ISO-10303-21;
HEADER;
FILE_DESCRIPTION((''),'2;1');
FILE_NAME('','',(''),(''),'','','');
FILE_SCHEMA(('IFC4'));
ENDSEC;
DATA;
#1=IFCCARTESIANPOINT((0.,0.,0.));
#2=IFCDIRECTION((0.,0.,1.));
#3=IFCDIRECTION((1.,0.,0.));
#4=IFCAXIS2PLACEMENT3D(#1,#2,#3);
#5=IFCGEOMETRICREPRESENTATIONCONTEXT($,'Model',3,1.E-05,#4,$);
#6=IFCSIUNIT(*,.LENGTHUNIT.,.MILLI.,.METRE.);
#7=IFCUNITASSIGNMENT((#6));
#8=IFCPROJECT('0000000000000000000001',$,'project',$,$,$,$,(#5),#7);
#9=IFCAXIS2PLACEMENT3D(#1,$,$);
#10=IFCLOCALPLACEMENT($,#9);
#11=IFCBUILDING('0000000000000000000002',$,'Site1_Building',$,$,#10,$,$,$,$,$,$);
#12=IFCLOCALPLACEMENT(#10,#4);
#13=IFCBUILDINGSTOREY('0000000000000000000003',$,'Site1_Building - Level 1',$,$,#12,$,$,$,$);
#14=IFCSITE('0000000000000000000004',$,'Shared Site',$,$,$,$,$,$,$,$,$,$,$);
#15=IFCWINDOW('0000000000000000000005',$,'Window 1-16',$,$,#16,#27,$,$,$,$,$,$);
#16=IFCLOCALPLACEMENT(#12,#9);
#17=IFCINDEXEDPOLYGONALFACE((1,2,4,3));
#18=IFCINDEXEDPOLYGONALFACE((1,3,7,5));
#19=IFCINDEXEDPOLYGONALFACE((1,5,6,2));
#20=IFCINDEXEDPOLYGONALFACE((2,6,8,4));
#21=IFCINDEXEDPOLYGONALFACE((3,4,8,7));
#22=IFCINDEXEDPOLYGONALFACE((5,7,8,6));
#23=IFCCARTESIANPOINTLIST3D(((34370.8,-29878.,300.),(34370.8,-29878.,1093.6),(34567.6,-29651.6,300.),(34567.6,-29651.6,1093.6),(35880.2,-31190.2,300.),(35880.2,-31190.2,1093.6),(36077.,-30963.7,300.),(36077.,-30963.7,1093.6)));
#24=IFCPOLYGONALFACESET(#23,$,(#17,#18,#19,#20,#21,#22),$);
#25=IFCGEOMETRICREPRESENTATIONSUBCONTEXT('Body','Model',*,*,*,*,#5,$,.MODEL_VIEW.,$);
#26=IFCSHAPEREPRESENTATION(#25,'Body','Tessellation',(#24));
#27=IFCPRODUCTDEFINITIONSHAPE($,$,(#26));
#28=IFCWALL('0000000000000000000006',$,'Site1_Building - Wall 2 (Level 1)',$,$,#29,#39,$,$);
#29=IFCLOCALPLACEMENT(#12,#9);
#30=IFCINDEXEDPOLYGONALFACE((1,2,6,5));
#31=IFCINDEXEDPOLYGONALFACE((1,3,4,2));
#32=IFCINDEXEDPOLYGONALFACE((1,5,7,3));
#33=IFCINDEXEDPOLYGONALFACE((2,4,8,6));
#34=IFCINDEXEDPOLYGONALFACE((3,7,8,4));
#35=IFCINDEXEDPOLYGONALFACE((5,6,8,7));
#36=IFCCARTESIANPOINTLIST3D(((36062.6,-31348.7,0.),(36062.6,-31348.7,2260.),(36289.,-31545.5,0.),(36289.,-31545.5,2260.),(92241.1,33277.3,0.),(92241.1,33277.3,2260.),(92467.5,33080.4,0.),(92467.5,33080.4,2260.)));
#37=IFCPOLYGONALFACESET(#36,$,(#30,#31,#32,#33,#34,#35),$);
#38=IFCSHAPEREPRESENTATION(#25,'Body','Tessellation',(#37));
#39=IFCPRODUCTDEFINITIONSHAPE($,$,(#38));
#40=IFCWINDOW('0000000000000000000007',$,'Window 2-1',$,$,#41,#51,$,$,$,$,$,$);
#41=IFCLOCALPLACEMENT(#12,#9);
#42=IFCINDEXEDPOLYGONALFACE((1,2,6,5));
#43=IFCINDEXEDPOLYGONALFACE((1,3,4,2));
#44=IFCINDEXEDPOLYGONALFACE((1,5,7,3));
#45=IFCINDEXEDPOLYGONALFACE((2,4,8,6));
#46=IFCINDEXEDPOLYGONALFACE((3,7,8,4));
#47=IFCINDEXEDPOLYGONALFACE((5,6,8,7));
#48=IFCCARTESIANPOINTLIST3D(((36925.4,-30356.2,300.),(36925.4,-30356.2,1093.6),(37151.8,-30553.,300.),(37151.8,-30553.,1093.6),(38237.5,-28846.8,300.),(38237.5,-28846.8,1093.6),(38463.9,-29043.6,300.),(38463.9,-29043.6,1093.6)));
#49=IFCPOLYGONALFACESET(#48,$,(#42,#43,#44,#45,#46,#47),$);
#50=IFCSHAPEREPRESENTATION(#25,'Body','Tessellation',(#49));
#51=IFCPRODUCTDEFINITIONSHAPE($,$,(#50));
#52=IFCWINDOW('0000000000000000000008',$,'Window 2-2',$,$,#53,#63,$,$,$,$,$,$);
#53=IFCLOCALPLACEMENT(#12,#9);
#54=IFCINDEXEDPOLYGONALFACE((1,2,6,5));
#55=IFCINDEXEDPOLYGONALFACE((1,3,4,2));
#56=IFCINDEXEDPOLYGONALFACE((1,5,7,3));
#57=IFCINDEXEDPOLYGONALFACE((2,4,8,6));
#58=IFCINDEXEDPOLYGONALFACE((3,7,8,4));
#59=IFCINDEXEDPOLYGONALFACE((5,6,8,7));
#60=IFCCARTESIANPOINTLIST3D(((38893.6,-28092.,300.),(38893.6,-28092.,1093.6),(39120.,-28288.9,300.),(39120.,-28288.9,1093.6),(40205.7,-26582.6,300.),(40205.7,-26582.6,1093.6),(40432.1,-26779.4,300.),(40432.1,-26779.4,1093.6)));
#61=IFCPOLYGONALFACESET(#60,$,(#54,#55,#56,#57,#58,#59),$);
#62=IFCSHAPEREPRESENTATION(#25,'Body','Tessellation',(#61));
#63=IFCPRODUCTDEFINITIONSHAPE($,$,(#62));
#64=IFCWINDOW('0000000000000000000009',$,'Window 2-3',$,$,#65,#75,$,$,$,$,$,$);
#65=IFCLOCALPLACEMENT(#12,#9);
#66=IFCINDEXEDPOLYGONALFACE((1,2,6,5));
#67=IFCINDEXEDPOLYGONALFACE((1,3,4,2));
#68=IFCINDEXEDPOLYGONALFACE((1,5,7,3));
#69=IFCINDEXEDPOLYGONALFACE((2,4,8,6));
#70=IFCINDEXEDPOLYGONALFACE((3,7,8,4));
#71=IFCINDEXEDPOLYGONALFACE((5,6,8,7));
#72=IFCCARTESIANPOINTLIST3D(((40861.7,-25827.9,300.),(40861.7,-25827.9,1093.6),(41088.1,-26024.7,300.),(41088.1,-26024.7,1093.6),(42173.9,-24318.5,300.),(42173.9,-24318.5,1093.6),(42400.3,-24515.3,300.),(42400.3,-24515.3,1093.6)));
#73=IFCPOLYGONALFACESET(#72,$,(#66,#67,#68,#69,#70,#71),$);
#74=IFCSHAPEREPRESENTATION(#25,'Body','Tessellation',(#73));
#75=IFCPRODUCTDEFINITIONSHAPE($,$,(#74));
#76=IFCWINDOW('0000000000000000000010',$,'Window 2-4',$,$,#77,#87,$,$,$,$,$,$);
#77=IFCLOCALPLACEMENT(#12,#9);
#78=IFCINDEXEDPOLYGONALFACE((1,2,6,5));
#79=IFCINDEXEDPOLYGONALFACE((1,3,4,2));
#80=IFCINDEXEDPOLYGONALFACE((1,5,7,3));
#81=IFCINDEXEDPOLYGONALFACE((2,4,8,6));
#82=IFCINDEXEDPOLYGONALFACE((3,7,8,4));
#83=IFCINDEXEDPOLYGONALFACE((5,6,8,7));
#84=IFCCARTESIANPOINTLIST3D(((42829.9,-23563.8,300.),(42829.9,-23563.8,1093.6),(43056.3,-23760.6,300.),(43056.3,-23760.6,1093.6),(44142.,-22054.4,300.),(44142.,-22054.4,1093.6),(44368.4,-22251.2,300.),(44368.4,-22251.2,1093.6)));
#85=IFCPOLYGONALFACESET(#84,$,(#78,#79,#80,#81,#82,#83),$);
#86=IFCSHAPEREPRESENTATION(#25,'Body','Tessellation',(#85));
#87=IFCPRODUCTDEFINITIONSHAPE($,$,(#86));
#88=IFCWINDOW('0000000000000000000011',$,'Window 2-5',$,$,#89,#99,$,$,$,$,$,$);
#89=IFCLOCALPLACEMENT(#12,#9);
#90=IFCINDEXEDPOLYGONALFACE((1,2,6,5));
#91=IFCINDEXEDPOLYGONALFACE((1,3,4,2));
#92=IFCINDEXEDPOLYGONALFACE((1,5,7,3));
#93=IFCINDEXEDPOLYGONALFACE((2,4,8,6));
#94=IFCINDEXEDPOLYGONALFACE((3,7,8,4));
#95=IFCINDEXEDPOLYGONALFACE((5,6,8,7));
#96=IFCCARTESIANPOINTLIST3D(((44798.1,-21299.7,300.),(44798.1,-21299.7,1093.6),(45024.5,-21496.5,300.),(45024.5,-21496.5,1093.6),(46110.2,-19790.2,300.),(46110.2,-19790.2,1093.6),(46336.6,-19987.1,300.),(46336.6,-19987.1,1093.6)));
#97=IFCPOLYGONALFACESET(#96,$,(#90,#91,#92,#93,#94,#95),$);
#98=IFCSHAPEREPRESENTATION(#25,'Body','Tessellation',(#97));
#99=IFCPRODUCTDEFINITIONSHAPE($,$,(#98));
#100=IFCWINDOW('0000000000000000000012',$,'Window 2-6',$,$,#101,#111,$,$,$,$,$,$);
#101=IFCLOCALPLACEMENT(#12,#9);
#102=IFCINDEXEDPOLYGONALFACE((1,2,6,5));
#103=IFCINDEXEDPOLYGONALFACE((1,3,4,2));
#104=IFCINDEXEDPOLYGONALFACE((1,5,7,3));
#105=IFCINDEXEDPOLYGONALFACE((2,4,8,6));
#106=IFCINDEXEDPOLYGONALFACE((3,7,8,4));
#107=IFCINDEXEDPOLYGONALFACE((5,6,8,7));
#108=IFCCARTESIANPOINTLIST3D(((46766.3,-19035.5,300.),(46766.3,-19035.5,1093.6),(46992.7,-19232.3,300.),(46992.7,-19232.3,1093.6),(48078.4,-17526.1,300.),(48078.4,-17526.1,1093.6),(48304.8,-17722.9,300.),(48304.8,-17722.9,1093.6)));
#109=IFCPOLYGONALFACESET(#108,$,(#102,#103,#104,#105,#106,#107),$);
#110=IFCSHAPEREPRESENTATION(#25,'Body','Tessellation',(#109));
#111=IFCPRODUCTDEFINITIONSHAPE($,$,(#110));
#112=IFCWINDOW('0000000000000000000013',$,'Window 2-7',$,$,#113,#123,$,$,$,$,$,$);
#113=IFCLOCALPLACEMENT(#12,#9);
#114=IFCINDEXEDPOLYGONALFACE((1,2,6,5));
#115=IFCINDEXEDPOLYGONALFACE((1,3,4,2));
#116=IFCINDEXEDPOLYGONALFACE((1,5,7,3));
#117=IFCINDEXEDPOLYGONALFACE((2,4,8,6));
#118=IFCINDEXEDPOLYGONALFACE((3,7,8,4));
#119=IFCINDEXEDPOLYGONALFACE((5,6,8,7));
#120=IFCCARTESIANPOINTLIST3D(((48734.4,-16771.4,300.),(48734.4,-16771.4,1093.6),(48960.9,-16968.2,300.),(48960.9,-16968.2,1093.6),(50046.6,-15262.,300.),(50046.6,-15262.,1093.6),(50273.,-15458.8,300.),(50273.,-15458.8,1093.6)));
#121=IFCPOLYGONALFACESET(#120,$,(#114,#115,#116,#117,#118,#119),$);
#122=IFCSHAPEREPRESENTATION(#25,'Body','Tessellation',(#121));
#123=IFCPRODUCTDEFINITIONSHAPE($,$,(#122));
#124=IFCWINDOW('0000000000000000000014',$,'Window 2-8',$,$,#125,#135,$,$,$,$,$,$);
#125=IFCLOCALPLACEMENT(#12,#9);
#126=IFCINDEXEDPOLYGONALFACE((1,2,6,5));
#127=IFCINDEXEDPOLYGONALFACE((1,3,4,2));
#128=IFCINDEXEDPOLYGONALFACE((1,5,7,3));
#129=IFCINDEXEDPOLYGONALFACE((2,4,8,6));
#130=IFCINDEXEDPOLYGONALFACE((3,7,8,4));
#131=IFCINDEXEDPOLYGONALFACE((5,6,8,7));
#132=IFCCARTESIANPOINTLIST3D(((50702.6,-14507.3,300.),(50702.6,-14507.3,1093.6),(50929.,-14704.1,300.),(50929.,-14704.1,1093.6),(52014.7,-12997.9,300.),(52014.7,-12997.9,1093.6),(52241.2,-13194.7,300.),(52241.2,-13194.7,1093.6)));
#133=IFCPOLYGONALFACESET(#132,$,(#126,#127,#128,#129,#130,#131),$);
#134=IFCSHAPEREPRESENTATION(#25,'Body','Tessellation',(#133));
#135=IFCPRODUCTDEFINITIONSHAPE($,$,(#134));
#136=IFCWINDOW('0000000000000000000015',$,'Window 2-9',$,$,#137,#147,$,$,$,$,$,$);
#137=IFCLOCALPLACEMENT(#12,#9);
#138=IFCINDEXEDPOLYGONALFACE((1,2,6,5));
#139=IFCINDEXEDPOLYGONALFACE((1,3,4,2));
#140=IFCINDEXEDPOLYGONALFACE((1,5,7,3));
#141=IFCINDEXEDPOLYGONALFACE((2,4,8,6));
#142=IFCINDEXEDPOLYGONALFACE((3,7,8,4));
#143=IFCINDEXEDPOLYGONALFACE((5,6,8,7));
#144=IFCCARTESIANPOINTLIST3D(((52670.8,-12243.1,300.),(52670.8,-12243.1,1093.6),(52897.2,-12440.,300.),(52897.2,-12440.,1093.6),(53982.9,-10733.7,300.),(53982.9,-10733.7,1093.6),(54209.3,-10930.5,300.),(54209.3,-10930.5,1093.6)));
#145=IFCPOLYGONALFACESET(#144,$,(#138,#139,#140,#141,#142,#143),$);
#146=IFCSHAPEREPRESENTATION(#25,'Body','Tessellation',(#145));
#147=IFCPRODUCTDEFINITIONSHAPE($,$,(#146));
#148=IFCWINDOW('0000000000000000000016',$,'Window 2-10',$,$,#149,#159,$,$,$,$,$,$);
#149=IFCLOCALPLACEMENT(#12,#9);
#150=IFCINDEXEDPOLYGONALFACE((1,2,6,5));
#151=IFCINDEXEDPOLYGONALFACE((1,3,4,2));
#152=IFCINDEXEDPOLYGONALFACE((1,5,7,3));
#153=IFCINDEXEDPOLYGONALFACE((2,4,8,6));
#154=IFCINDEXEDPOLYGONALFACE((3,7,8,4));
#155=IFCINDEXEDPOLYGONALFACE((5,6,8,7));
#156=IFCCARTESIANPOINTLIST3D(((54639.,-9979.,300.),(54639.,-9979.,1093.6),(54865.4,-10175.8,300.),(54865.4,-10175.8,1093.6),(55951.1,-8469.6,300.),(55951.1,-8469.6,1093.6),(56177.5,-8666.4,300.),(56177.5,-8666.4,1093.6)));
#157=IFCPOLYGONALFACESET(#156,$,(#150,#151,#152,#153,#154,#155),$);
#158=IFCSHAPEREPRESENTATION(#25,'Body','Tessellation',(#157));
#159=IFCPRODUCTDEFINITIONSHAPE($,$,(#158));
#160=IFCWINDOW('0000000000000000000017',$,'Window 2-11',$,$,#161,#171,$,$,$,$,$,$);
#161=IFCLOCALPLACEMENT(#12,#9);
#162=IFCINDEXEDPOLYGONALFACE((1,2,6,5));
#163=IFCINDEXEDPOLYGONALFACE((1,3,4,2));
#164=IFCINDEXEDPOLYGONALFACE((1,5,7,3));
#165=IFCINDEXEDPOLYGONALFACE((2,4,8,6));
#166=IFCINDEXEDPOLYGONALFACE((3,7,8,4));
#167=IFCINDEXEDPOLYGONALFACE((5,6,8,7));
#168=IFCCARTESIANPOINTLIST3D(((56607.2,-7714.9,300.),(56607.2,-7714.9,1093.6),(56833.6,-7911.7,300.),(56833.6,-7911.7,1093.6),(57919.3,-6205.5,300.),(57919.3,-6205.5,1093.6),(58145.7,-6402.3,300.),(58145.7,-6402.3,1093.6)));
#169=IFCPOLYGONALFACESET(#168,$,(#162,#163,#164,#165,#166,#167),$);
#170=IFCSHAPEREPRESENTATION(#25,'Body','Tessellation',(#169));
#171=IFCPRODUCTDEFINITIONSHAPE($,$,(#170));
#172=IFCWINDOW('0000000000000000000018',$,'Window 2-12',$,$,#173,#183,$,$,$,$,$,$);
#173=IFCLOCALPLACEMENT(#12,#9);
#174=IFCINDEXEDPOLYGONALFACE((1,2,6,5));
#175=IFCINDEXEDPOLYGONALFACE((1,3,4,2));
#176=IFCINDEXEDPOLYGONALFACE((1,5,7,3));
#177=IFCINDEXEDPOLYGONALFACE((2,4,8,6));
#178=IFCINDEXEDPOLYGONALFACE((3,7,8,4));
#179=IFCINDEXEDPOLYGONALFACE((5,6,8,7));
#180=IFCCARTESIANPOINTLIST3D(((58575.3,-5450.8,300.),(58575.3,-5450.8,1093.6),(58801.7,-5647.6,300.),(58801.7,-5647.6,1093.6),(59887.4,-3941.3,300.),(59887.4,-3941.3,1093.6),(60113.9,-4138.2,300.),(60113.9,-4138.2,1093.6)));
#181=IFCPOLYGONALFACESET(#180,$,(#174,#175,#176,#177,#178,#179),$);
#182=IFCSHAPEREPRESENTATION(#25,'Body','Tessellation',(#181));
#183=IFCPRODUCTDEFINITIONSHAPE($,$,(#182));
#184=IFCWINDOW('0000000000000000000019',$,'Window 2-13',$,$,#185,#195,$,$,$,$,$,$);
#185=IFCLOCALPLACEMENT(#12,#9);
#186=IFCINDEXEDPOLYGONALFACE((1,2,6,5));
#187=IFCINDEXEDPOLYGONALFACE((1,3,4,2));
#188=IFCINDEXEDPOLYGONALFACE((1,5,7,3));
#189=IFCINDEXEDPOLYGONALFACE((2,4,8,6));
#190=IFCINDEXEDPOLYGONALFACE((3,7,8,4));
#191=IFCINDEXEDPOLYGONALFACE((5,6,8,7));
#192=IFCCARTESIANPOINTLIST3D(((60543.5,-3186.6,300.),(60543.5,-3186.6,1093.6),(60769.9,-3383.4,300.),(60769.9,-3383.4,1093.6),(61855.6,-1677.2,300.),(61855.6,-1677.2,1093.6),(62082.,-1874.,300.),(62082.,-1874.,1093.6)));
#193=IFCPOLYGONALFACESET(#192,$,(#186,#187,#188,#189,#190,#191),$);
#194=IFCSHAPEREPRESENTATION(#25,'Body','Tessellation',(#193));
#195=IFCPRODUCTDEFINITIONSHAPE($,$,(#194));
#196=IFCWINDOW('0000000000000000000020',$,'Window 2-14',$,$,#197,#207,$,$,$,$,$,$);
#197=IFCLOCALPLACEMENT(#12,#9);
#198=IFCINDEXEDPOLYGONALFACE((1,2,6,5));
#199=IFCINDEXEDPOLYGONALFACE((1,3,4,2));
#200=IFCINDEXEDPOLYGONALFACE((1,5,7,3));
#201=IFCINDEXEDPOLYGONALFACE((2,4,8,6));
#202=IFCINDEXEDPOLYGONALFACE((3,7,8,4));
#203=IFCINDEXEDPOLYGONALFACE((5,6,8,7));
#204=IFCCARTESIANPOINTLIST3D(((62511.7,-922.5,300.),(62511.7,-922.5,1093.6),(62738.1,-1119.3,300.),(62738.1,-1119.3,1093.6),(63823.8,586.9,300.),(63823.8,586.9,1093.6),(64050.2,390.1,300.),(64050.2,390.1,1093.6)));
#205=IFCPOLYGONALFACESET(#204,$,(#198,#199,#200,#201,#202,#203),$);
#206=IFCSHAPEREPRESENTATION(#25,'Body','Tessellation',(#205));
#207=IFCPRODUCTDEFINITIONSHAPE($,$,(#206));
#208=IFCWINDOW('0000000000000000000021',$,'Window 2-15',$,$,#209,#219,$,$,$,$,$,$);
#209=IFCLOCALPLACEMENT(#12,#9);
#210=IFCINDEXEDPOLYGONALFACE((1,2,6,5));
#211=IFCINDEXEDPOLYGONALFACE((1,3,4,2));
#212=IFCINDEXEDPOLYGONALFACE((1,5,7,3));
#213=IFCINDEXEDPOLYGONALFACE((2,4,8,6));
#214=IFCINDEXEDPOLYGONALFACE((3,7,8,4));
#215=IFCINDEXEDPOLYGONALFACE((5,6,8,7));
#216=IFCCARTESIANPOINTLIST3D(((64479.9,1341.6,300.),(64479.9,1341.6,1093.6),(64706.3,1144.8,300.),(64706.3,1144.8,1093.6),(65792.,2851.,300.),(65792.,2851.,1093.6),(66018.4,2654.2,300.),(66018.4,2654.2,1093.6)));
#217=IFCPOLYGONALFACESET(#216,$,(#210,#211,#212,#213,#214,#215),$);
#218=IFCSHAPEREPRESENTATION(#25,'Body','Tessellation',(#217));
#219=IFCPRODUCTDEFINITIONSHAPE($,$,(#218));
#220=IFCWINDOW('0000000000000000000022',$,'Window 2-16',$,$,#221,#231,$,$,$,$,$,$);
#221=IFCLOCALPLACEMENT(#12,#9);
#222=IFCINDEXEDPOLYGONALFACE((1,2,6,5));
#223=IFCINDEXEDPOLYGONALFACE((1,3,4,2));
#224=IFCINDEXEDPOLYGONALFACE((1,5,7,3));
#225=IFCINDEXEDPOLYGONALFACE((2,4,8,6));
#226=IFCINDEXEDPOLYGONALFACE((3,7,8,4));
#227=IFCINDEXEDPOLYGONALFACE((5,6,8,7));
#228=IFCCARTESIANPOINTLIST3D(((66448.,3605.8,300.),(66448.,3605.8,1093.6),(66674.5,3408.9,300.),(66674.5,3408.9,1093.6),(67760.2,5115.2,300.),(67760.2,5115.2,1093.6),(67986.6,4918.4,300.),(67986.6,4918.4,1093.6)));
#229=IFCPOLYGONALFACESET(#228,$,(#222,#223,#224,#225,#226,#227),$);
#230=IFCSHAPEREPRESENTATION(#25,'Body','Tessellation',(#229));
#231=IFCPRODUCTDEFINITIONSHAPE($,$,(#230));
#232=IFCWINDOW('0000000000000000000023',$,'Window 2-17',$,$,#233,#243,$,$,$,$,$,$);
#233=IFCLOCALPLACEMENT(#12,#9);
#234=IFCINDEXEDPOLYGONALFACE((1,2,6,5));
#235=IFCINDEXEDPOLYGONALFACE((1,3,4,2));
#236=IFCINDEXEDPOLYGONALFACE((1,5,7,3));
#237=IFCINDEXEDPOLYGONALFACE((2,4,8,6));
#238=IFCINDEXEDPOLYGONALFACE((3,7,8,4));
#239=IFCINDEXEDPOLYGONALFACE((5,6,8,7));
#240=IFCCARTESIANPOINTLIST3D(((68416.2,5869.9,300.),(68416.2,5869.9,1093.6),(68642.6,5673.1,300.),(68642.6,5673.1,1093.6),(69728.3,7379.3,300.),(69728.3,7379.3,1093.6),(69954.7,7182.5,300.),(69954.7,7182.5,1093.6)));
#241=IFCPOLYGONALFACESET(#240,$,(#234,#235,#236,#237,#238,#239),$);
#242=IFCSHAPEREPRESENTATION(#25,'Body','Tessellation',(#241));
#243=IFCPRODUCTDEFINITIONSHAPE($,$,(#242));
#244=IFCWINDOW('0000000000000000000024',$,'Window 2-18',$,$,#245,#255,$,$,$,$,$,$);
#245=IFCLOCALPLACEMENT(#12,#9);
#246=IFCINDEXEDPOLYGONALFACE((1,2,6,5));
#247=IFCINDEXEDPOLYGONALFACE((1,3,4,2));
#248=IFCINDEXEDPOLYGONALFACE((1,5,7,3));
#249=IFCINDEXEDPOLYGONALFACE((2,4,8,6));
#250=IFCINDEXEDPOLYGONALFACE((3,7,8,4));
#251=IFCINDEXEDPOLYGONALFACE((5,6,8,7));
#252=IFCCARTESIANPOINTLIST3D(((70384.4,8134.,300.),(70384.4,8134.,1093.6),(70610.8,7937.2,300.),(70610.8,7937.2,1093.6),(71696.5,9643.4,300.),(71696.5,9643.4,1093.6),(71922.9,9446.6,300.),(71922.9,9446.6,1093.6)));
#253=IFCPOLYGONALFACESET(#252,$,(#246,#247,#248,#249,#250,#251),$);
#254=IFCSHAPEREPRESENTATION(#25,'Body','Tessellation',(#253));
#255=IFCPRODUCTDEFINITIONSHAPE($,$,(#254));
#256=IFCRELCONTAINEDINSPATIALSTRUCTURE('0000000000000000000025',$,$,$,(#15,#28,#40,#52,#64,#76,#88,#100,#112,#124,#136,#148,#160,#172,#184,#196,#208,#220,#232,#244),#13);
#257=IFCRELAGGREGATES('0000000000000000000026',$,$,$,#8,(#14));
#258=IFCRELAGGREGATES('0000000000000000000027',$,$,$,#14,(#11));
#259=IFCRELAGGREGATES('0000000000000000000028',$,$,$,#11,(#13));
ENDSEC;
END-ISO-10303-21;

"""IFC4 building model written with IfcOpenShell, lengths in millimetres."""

from ifc_helpers import new_model, si_unit, frame, origin, origin_with_axes, place, context, subcontext, project, spatial, indexed_curve, outline, extrude, element, save


model = new_model("IFC4")

# Units and contexts
model_context = context("Model", 3, precision=1e-05, world=origin_with_axes())
body_context = subcontext(model_context, "Body", "Model", "MODEL_VIEW")
ifc_project = project(units=[si_unit("LENGTHUNIT", "METRE", prefix="MILLI")], contexts=[model_context])

# Site, building, storey
site = spatial("IfcSite", under=ifc_project, Name="Shared Site")
building_placement = place(None, origin())
building = spatial("IfcBuilding", under=site, at=building_placement, Name="Site1_Building")
storey_placement = place(building_placement, origin_with_axes())
storey = spatial("IfcBuildingStorey", under=building, at=storey_placement, Name="Site1_Building - Level 1")

# Window
window_placement = place(storey_placement, frame((34370.8, -29878.0, 300.0), z_axis=(0.0, 0.0, 1.0), x_axis=(0.75471, -0.656059, 0.0)))
element("IfcWindow", 1, at=window_placement, inside=storey, Name="Window 1-16", context=body_context, shape_type="SweptSolid", body=[
    extrude(outline(indexed_curve([(0.0, 0.0), (0.0, 300.0), (2000.0, 300.0), (2000.0, 0.0), (0.0, 0.0)], self_intersect=False)), origin_with_axes(), (0.0, 0.0, 1.0), 793.6),
])

# Wall
wall_placement = place(storey_placement, frame((36289.0, -31545.5, 0.0), z_axis=(0.0, 0.0, 1.0), x_axis=(0.656059, 0.75471, 0.0)))
element("IfcWall", 2, at=wall_placement, inside=storey, Name="Site1_Building - Wall 2 (Level 1)", context=body_context, shape_type="SweptSolid", body=[
    extrude(outline(indexed_curve([(0.0, 0.0), (0.0, 300.0), (85630.3, 300.0), (85630.3, 0.0), (0.0, 0.0)], self_intersect=False)), origin_with_axes(), (0.0, 0.0, 1.0), 2260.0),
])

# Windows
for number, where, z_axis, x_axis, name in (
    (3, (37151.8, -30553.0, 300.0), (0.0, 0.0, 1.0), (0.656059, 0.75471, 0.0), "Window 2-1"),
    (4, (39120.0, -28288.9, 300.0), (0.0, 0.0, 1.0), (0.656059, 0.75471, 0.0), "Window 2-2"),
    (5, (41088.1, -26024.7, 300.0), (0.0, 0.0, 1.0), (0.656059, 0.75471, 0.0), "Window 2-3"),
    (6, (43056.3, -23760.6, 300.0), (0.0, 0.0, 1.0), (0.656059, 0.75471, 0.0), "Window 2-4"),
    (7, (45024.5, -21496.5, 300.0), (0.0, 0.0, 1.0), (0.656059, 0.75471, 0.0), "Window 2-5"),
    (8, (46992.7, -19232.3, 300.0), (0.0, 0.0, 1.0), (0.656059, 0.75471, 0.0), "Window 2-6"),
    (9, (48960.9, -16968.2, 300.0), (0.0, 0.0, 1.0), (0.656059, 0.75471, 0.0), "Window 2-7"),
    (10, (50929.0, -14704.1, 300.0), (0.0, 0.0, 1.0), (0.656059, 0.75471, 0.0), "Window 2-8"),
    (11, (52897.2, -12440.0, 300.0), (0.0, 0.0, 1.0), (0.656059, 0.75471, 0.0), "Window 2-9"),
    (12, (54865.4, -10175.8, 300.0), (0.0, 0.0, 1.0), (0.656059, 0.75471, 0.0), "Window 2-10"),
    (13, (56833.6, -7911.7, 300.0), (0.0, 0.0, 1.0), (0.656059, 0.75471, 0.0), "Window 2-11"),
    (14, (58801.7, -5647.6, 300.0), (0.0, 0.0, 1.0), (0.656059, 0.75471, 0.0), "Window 2-12"),
    (15, (60769.9, -3383.4, 300.0), (0.0, 0.0, 1.0), (0.656059, 0.75471, 0.0), "Window 2-13"),
    (16, (62738.1, -1119.3, 300.0), (0.0, 0.0, 1.0), (0.656059, 0.75471, 0.0), "Window 2-14"),
    (17, (64706.3, 1144.8, 300.0), (0.0, 0.0, 1.0), (0.656059, 0.75471, 0.0), "Window 2-15"),
    (18, (66674.5, 3408.9, 300.0), (0.0, 0.0, 1.0), (0.656059, 0.75471, 0.0), "Window 2-16"),
    (19, (68642.6, 5673.1, 300.0), (0.0, 0.0, 1.0), (0.656059, 0.75471, 0.0), "Window 2-17"),
    (20, (70610.8, 7937.2, 300.0), (0.0, 0.0, 1.0), (0.656059, 0.75471, 0.0), "Window 2-18"),
):
    element("IfcWindow", number, at=place(storey_placement, frame(where, z_axis=z_axis, x_axis=x_axis)), inside=storey, Name=name, context=body_context, shape_type="SweptSolid", body=[
        extrude(outline(indexed_curve([(0.0, 0.0), (0.0, 300.0), (2000.0, 300.0), (2000.0, 0.0), (0.0, 0.0)], self_intersect=False)), origin_with_axes(), (0.0, 0.0, 1.0), 793.6),
    ])

save(model, "model.ifc")
